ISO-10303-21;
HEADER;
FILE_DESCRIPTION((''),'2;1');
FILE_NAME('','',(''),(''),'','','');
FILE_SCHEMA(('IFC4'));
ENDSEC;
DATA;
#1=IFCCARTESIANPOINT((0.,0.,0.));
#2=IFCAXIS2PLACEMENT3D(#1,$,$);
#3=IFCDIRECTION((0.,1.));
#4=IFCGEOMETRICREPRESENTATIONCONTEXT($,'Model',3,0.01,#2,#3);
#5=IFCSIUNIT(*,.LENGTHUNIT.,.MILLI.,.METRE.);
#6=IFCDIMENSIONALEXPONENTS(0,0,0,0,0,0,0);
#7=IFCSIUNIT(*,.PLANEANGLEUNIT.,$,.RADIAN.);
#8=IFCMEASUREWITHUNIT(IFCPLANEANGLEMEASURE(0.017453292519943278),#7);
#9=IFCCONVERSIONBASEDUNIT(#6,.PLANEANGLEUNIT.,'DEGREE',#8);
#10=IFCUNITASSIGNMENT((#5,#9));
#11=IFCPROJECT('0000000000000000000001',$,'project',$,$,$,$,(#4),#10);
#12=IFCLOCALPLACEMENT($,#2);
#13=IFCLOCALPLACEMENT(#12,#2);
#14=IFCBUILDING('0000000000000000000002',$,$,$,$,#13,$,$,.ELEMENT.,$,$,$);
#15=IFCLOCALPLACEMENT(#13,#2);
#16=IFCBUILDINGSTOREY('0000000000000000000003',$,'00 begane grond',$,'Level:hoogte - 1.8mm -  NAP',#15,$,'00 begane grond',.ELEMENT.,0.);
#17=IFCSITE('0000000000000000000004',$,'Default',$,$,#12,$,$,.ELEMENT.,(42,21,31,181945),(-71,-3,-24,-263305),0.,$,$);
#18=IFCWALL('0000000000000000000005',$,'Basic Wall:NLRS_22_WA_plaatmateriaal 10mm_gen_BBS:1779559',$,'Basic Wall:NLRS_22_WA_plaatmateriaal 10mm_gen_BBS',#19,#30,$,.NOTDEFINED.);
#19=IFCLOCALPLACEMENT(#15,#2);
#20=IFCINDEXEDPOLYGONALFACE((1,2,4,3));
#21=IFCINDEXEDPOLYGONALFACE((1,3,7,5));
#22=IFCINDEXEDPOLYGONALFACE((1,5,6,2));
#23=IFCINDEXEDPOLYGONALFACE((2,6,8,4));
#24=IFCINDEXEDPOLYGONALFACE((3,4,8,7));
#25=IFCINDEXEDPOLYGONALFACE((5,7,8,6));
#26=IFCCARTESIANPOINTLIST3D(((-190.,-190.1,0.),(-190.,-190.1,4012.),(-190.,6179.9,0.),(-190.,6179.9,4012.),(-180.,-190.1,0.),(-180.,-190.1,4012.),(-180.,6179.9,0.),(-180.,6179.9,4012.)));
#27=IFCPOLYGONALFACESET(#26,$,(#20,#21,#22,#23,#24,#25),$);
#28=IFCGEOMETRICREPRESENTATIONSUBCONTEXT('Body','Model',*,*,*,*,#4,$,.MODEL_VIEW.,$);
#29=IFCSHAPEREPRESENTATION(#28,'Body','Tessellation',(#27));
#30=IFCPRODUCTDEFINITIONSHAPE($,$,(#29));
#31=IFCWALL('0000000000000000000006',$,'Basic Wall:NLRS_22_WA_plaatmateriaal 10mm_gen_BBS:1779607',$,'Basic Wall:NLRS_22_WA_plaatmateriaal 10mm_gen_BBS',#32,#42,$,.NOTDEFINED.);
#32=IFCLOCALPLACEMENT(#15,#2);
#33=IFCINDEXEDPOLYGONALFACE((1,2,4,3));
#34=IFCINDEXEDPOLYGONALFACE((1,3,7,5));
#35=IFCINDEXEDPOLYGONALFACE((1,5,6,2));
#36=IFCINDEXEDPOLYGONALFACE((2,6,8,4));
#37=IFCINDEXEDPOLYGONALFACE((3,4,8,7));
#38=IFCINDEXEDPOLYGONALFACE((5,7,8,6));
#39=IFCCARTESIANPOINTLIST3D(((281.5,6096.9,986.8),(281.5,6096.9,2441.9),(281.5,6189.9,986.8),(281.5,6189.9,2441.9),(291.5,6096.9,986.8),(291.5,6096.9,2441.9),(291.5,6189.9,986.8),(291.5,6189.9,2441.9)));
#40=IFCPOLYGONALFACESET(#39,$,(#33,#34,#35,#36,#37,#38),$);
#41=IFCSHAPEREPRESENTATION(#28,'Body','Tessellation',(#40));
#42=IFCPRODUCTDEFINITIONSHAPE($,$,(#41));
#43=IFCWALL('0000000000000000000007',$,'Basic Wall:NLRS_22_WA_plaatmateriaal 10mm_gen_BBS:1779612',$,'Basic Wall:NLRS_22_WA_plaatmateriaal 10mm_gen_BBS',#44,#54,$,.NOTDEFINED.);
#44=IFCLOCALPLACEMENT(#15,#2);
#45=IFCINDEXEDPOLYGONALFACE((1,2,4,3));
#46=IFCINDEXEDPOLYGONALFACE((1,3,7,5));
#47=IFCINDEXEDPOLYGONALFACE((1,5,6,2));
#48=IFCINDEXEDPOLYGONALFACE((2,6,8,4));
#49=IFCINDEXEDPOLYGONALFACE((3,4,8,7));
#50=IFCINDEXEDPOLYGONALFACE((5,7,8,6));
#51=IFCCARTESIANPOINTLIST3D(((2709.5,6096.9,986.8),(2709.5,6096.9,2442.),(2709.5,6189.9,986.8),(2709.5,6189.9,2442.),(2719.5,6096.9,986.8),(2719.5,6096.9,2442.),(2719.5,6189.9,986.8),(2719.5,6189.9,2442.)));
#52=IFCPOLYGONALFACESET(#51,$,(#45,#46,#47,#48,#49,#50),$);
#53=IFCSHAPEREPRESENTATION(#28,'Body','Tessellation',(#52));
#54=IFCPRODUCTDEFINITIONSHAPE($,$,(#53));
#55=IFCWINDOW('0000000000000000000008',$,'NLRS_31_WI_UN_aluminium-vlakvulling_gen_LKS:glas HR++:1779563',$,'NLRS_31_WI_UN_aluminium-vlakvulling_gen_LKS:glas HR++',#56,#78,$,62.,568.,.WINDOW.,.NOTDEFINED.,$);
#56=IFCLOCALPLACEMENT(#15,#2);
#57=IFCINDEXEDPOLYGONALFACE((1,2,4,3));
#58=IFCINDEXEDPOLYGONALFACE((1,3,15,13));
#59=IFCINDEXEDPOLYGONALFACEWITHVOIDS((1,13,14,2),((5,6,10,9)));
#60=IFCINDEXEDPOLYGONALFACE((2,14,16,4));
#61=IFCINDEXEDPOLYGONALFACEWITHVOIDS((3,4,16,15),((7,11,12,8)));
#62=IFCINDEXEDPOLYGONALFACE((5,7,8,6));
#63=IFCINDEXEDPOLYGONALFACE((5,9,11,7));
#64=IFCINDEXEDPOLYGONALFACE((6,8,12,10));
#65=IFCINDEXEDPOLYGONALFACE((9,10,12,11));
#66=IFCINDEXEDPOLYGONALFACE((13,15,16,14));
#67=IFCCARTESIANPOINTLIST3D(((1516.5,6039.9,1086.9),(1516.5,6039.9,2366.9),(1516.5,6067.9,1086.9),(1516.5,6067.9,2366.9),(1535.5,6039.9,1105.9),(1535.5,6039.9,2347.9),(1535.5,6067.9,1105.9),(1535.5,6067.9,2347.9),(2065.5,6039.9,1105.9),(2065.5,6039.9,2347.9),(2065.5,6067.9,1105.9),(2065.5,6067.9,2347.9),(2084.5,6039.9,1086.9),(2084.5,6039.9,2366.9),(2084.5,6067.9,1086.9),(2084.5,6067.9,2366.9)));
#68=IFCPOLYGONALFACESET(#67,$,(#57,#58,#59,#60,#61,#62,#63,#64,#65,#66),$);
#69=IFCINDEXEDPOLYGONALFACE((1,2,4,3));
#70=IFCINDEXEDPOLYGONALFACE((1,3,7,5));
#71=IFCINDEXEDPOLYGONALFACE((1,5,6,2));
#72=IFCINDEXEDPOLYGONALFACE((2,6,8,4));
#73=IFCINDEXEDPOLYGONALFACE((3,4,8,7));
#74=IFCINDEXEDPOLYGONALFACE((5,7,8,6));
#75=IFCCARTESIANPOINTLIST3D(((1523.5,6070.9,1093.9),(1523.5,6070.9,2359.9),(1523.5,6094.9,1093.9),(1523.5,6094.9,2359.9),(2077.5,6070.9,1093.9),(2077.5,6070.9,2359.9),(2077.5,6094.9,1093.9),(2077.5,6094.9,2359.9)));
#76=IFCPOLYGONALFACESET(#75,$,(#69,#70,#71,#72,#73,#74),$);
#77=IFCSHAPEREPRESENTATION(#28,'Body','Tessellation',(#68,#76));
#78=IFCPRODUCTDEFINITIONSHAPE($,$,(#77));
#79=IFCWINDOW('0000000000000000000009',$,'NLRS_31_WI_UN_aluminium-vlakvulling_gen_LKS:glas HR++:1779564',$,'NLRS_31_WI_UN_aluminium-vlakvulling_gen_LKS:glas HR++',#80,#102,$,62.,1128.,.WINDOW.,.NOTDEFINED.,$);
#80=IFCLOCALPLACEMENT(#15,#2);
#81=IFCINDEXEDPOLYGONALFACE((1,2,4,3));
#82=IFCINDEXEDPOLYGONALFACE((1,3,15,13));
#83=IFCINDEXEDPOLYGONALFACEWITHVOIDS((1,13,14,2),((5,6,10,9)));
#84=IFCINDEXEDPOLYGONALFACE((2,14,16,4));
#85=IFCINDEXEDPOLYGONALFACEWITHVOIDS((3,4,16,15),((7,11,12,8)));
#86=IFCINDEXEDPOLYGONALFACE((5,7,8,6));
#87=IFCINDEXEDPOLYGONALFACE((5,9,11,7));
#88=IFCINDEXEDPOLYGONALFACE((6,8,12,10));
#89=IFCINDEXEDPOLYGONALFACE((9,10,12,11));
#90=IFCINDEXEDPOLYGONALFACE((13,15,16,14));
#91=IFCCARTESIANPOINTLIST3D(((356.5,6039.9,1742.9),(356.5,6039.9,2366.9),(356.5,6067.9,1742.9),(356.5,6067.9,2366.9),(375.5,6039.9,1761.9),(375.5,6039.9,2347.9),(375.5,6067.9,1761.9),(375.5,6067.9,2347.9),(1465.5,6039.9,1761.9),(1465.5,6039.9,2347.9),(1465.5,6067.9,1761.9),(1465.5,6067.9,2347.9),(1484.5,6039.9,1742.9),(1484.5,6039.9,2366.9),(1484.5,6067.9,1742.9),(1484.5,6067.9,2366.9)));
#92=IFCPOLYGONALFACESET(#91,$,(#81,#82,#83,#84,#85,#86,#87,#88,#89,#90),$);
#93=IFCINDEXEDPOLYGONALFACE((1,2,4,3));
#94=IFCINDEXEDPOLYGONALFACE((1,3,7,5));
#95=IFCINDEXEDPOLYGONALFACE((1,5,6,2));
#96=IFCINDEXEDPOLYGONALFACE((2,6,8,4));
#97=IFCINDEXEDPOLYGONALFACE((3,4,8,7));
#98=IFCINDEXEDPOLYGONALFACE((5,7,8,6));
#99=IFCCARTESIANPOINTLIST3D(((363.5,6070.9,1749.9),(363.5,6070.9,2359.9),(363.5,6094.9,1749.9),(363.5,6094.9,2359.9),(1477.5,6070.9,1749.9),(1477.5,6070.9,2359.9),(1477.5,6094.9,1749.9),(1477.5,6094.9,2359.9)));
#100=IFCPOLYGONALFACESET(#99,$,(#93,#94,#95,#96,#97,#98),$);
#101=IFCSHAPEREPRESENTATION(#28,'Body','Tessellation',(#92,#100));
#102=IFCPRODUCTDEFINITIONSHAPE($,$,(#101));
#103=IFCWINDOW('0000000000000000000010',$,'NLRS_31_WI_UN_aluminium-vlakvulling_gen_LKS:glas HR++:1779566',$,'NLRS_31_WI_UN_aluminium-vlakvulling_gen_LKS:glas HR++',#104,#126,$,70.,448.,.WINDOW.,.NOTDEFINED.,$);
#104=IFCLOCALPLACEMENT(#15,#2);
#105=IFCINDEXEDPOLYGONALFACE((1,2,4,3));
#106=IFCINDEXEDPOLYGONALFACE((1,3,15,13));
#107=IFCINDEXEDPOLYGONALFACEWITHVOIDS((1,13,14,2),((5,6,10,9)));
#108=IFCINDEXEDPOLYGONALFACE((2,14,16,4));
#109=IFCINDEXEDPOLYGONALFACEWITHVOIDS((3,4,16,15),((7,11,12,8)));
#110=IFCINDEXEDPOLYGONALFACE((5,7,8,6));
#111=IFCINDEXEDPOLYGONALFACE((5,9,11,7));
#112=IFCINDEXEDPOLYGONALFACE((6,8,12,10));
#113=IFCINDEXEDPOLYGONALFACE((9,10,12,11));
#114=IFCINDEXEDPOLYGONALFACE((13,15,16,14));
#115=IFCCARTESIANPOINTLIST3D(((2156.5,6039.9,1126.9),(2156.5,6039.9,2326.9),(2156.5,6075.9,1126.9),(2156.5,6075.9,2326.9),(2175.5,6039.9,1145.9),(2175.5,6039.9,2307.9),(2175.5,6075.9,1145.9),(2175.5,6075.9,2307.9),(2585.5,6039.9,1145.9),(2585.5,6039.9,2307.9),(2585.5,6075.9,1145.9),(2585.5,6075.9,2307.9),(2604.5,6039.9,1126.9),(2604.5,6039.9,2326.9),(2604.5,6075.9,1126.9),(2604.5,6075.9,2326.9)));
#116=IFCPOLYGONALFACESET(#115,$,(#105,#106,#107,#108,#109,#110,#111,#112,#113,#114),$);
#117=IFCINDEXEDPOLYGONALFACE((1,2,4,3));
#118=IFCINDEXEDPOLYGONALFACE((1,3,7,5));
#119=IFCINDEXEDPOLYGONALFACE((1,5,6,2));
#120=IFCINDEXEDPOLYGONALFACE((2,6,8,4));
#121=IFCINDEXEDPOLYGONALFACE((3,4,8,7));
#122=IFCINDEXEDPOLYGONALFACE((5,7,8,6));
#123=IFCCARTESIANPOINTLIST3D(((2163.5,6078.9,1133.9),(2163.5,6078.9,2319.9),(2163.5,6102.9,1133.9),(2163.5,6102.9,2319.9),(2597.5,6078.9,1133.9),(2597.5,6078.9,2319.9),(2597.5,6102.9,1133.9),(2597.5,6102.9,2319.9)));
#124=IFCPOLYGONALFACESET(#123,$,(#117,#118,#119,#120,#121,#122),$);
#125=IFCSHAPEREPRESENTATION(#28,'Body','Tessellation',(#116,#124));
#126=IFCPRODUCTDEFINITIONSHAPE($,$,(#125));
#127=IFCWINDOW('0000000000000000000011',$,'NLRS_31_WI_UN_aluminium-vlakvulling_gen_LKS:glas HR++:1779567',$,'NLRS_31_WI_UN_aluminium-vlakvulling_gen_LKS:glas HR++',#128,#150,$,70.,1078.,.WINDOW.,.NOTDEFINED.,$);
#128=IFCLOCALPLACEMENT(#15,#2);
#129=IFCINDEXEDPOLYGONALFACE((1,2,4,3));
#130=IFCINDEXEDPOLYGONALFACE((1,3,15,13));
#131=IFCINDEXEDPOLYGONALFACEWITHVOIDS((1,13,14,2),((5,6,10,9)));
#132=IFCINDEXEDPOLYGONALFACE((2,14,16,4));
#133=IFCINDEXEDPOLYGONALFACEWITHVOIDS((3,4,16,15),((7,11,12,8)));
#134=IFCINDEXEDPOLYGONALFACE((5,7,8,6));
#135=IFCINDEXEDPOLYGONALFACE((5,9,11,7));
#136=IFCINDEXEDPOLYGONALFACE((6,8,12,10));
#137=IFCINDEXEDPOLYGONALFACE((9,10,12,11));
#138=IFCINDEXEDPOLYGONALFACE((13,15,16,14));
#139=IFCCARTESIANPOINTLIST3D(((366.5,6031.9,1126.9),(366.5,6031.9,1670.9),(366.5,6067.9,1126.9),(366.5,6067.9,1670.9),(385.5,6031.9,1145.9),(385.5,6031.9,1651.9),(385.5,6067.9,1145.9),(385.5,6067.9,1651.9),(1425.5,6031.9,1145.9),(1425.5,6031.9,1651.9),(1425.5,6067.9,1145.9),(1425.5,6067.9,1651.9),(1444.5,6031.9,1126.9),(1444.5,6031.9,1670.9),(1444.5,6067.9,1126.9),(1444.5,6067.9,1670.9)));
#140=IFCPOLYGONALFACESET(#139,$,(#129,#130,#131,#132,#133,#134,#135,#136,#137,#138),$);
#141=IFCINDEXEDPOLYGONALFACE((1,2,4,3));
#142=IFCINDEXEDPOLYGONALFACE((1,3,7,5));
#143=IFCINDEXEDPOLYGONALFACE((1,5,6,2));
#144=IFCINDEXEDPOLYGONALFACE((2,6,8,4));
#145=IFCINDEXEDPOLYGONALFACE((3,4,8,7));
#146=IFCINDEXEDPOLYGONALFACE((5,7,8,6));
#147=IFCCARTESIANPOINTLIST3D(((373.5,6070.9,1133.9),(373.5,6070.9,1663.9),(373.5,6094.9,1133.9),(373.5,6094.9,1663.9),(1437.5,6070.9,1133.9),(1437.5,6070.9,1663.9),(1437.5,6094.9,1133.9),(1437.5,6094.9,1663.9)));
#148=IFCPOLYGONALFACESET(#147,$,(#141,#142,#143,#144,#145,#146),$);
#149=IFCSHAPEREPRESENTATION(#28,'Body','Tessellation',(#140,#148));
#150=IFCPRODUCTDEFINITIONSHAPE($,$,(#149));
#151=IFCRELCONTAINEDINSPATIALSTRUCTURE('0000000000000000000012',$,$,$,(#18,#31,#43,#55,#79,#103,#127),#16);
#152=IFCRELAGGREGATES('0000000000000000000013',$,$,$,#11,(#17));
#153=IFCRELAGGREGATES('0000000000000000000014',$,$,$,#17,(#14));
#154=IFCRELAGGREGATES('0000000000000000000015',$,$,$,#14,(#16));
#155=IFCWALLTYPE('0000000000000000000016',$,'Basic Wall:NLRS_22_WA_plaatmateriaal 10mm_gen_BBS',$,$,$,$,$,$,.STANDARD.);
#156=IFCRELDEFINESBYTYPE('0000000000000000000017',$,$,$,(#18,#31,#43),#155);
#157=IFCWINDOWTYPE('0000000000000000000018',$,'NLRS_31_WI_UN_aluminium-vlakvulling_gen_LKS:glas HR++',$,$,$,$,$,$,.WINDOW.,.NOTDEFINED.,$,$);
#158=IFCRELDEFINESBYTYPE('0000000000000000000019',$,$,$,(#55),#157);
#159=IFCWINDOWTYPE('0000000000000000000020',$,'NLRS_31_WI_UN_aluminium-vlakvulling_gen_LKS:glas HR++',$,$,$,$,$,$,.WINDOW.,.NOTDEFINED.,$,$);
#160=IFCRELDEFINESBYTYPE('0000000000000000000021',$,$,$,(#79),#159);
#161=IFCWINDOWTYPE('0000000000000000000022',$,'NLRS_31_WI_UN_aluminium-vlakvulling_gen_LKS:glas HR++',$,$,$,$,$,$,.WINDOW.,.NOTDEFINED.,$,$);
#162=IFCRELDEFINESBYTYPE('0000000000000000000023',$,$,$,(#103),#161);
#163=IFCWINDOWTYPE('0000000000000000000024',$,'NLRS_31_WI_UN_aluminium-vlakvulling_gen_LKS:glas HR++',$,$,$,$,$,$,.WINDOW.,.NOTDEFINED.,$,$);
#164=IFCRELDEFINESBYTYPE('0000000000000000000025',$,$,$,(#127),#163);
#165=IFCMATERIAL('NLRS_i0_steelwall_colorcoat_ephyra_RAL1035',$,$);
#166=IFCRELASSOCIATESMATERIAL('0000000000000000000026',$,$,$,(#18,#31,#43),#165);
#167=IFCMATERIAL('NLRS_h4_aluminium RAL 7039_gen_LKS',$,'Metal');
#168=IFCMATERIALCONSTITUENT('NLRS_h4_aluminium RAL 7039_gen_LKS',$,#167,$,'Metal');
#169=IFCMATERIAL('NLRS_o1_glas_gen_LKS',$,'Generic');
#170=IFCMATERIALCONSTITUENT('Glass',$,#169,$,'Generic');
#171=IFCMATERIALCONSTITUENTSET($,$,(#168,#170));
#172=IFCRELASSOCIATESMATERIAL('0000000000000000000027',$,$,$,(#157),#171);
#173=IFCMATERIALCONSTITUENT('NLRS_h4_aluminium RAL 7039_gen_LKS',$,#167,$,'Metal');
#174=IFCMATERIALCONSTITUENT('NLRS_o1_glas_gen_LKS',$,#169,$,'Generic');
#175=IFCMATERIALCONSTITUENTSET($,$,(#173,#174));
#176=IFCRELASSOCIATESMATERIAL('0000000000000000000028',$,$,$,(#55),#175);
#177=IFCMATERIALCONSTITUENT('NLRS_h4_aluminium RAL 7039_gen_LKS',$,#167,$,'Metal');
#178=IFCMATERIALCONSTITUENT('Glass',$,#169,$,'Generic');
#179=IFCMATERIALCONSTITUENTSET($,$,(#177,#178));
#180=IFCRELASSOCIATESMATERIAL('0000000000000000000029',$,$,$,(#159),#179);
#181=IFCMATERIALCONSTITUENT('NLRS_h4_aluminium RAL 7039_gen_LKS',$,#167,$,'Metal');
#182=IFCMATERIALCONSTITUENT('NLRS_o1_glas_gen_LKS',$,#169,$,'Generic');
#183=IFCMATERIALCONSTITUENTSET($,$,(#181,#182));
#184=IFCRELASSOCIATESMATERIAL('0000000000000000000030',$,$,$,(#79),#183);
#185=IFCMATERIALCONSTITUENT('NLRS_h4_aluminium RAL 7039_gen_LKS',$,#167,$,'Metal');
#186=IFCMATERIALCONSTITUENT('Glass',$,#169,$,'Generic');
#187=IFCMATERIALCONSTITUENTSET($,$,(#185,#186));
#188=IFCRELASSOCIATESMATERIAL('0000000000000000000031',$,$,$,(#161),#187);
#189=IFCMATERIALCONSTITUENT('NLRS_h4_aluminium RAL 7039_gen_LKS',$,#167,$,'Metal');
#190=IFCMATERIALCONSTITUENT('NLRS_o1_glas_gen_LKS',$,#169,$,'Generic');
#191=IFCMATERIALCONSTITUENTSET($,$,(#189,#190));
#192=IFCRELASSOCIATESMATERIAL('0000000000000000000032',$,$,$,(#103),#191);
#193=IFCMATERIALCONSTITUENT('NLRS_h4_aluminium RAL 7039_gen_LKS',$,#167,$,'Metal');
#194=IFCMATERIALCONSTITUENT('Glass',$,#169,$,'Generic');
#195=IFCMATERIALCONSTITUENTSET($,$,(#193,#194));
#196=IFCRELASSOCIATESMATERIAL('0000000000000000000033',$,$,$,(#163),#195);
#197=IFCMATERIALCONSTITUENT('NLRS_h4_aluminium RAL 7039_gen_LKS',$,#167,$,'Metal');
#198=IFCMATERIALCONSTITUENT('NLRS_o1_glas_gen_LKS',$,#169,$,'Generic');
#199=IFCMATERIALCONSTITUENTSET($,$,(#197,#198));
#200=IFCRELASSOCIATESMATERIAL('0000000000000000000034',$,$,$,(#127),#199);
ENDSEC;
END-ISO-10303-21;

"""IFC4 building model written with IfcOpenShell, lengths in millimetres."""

from ifc_helpers import new_model, entity, si_unit, converted_unit, direction, frame, origin, place, context, subcontext, project, spatial, indexed_curve, outline, extrude, source, transform, mapped, material, constituent, constituent_set, type_object, type_shapes, element, save


model = new_model("IFC4")

# Units and contexts
model_context = context("Model", 3, precision=0.01, world=origin(), true_north=direction((0.0, 1.0)))
body_context = subcontext(model_context, "Body", "Model", "MODEL_VIEW")
ifc_project = project(units=[si_unit("LENGTHUNIT", "METRE", prefix="MILLI"), converted_unit("PLANEANGLEUNIT", "DEGREE", entity("IfcPlaneAngleMeasure", 0.017453292519943278), si_unit("PLANEANGLEUNIT", "RADIAN"), dimensions=[0, 0, 0, 0, 0, 0, 0])], contexts=[model_context])

# Site, building, storey
site_placement = place(None, origin())
site = spatial("IfcSite", under=ifc_project, at=site_placement, Name="Default", CompositionType="ELEMENT", RefLatitude=(42, 21, 31, 181945), RefLongitude=(-71, -3, -24, -263305), RefElevation=0.0)
building_placement = place(site_placement, origin())
building = spatial("IfcBuilding", under=site, at=building_placement, CompositionType="ELEMENT")
storey_placement = place(building_placement, origin())
storey = spatial("IfcBuildingStorey", under=building, at=storey_placement, Name="00 begane grond", ObjectType="Level:hoogte - 1.8mm -  NAP", LongName="00 begane grond", CompositionType="ELEMENT", Elevation=0.0)

# Walls
ifc_material_1 = material(Name="NLRS_i0_steelwall_colorcoat_ephyra_RAL1035")
wall_type_1 = type_object("IfcWallType", Name="Basic Wall:NLRS_22_WA_plaatmateriaal 10mm_gen_BBS", PredefinedType="STANDARD")
wall_1_placement = place(storey_placement, frame((-185.0, 6179.9, 0.0), z_axis=(0.0, 0.0, 1.0), x_axis=(0.0, -1.0, 0.0)))
element("IfcWall", 1, at=wall_1_placement, inside=storey, type_object=wall_type_1, material=ifc_material_1, Name="Basic Wall:NLRS_22_WA_plaatmateriaal 10mm_gen_BBS:1779559", ObjectType="Basic Wall:NLRS_22_WA_plaatmateriaal 10mm_gen_BBS", PredefinedType="NOTDEFINED", context=body_context, shape_type="SweptSolid", body=[
    extrude(outline(indexed_curve([(6370.0, 5.0), (0.0, 5.0), (0.0, -5.0), (6370.0, -5.0), (6370.0, 5.0)], self_intersect=False)), origin(), (0.0, 0.0, 1.0), 4012.0),
])
wall_2_placement = place(storey_placement, frame((286.5, 6096.9, 986.8), z_axis=(0.0, 0.0, 1.0), x_axis=(0.0, 1.0, 0.0)))
element("IfcWall", 2, at=wall_2_placement, inside=storey, type_object=wall_type_1, material=ifc_material_1, Name="Basic Wall:NLRS_22_WA_plaatmateriaal 10mm_gen_BBS:1779607", ObjectType="Basic Wall:NLRS_22_WA_plaatmateriaal 10mm_gen_BBS", PredefinedType="NOTDEFINED", context=body_context, shape_type="SweptSolid", body=[
    extrude(outline(indexed_curve([(93.0, 5.0), (0.0, 5.0), (0.0, -5.0), (93.0, -5.0), (93.0, 5.0)], self_intersect=False)), origin(), (0.0, 0.0, 1.0), 1455.1),
])
wall_3_placement = place(storey_placement, frame((2714.5, 6096.9, 986.8), z_axis=(0.0, 0.0, 1.0), x_axis=(0.0, 1.0, 0.0)))
element("IfcWall", 3, at=wall_3_placement, inside=storey, type_object=wall_type_1, material=ifc_material_1, Name="Basic Wall:NLRS_22_WA_plaatmateriaal 10mm_gen_BBS:1779612", ObjectType="Basic Wall:NLRS_22_WA_plaatmateriaal 10mm_gen_BBS", PredefinedType="NOTDEFINED", context=body_context, shape_type="SweptSolid", body=[
    extrude(outline(indexed_curve([(93.0, 5.0), (0.0, 5.0), (0.0, -5.0), (93.0, -5.0), (93.0, 5.0)], self_intersect=False)), origin(), (0.0, 0.0, 1.0), 1455.2),
])

# Windows
ifc_material_2 = material(Name="NLRS_h4_aluminium RAL 7039_gen_LKS", Category="Metal")
ifc_constituent_1 = constituent(ifc_material_2, Name="NLRS_h4_aluminium RAL 7039_gen_LKS", Category="Metal")
ifc_material_3 = material(Name="NLRS_o1_glas_gen_LKS", Category="Generic")
ifc_constituent_2 = constituent(ifc_material_3, Name="NLRS_o1_glas_gen_LKS", Category="Generic")
ifc_constituent_set_1 = constituent_set(constituents=[ifc_constituent_1, ifc_constituent_2])
ifc_constituent_3 = constituent(ifc_material_2, Name="NLRS_h4_aluminium RAL 7039_gen_LKS", Category="Metal")
ifc_constituent_4 = constituent(ifc_material_3, Name="Glass", Category="Generic")
ifc_constituent_set_2 = constituent_set(constituents=[ifc_constituent_3, ifc_constituent_4])
window_type_1 = type_object("IfcWindowType", Name="NLRS_31_WI_UN_aluminium-vlakvulling_gen_LKS:glas HR++", PartitioningType="NOTDEFINED", PredefinedType="WINDOW", material=ifc_constituent_set_2)
shared_shape_1 = source(origin(), body_context, "Body", "SweptSolid", [
    extrude(outline(indexed_curve([(-640.0, -284.0), (640.0, -284.0), (640.0, 284.0), (-640.0, 284.0), (-640.0, -284.0)], self_intersect=False), holes=[indexed_curve([(621.0, -265.0), (-621.0, -265.0), (-621.0, 265.0), (621.0, 265.0), (621.0, -265.0)], self_intersect=False)]), frame((0.0, 34.0, 640.0), z_axis=(0.0, 1.0, 0.0), x_axis=(0.0, 0.0, -1.0)), (0.0, 0.0, 1.0), 28.0),
    extrude(outline(indexed_curve([(-12.0, -277.0), (12.0, -277.0), (12.0, 277.0), (-12.0, 277.0), (-12.0, -277.0)], self_intersect=False)), frame((0.0, 19.0, 7.0), z_axis=(0.0, 0.0, 1.0), x_axis=(0.0, -1.0, 0.0)), (0.0, 0.0, 1.0), 1266.0),
])
type_shapes(window_type_1, [shared_shape_1])
window_1_placement = place(storey_placement, frame((1800.5, 6101.9, 1086.9), z_axis=(0.0, 0.0, 1.0), x_axis=(-1.0, 0.0, 0.0)))
element("IfcWindow", 4, at=window_1_placement, inside=storey, type_object=window_type_1, material=ifc_constituent_set_1, Name="NLRS_31_WI_UN_aluminium-vlakvulling_gen_LKS:glas HR++:1779563", ObjectType="NLRS_31_WI_UN_aluminium-vlakvulling_gen_LKS:glas HR++", OverallHeight=62.0, OverallWidth=568.0, PartitioningType="NOTDEFINED", PredefinedType="WINDOW", context=body_context, shape_type="MappedRepresentation", body=[
    mapped(shared_shape_1, transform((0.0, 0.0, 0.0), scale=1.0)),
])
ifc_constituent_5 = constituent(ifc_material_2, Name="NLRS_h4_aluminium RAL 7039_gen_LKS", Category="Metal")
ifc_constituent_6 = constituent(ifc_material_3, Name="NLRS_o1_glas_gen_LKS", Category="Generic")
ifc_constituent_set_3 = constituent_set(constituents=[ifc_constituent_5, ifc_constituent_6])
ifc_constituent_7 = constituent(ifc_material_2, Name="NLRS_h4_aluminium RAL 7039_gen_LKS", Category="Metal")
ifc_constituent_8 = constituent(ifc_material_3, Name="Glass", Category="Generic")
ifc_constituent_set_4 = constituent_set(constituents=[ifc_constituent_7, ifc_constituent_8])
window_type_2 = type_object("IfcWindowType", Name="NLRS_31_WI_UN_aluminium-vlakvulling_gen_LKS:glas HR++", PartitioningType="NOTDEFINED", PredefinedType="WINDOW", material=ifc_constituent_set_4)
shared_shape_2 = source(origin(), body_context, "Body", "SweptSolid", [
    extrude(outline(indexed_curve([(-312.0, -564.0), (312.0, -564.0), (312.0, 564.0), (-312.0, 564.0), (-312.0, -564.0)], self_intersect=False), holes=[indexed_curve([(293.0, -545.0), (-293.0, -545.0), (-293.0, 545.0), (293.0, 545.0), (293.0, -545.0)], self_intersect=False)]), frame((0.0, 34.0, 312.0), z_axis=(0.0, 1.0, 0.0), x_axis=(0.0, 0.0, -1.0)), (0.0, 0.0, 1.0), 28.0),
    extrude(outline(indexed_curve([(-12.0, -557.0), (12.0, -557.0), (12.0, 557.0), (-12.0, 557.0), (-12.0, -557.0)], self_intersect=False)), frame((0.0, 19.0, 7.0), z_axis=(0.0, 0.0, 1.0), x_axis=(0.0, -1.0, 0.0)), (0.0, 0.0, 1.0), 610.0),
])
type_shapes(window_type_2, [shared_shape_2])
window_2_placement = place(storey_placement, frame((920.5, 6101.9, 1742.9), z_axis=(0.0, 0.0, 1.0), x_axis=(-1.0, 0.0, 0.0)))
element("IfcWindow", 5, at=window_2_placement, inside=storey, type_object=window_type_2, material=ifc_constituent_set_3, Name="NLRS_31_WI_UN_aluminium-vlakvulling_gen_LKS:glas HR++:1779564", ObjectType="NLRS_31_WI_UN_aluminium-vlakvulling_gen_LKS:glas HR++", OverallHeight=62.0, OverallWidth=1128.0, PartitioningType="NOTDEFINED", PredefinedType="WINDOW", context=body_context, shape_type="MappedRepresentation", body=[
    mapped(shared_shape_2, transform((0.0, 0.0, 0.0), scale=1.0)),
])
ifc_constituent_9 = constituent(ifc_material_2, Name="NLRS_h4_aluminium RAL 7039_gen_LKS", Category="Metal")
ifc_constituent_10 = constituent(ifc_material_3, Name="NLRS_o1_glas_gen_LKS", Category="Generic")
ifc_constituent_set_5 = constituent_set(constituents=[ifc_constituent_9, ifc_constituent_10])
ifc_constituent_11 = constituent(ifc_material_2, Name="NLRS_h4_aluminium RAL 7039_gen_LKS", Category="Metal")
ifc_constituent_12 = constituent(ifc_material_3, Name="Glass", Category="Generic")
ifc_constituent_set_6 = constituent_set(constituents=[ifc_constituent_11, ifc_constituent_12])
window_type_3 = type_object("IfcWindowType", Name="NLRS_31_WI_UN_aluminium-vlakvulling_gen_LKS:glas HR++", PartitioningType="NOTDEFINED", PredefinedType="WINDOW", material=ifc_constituent_set_6)
shared_shape_3 = source(origin(), body_context, "Body", "SweptSolid", [
    extrude(outline(indexed_curve([(-600.0, -224.0), (600.0, -224.0), (600.0, 224.0), (-600.0, 224.0), (-600.0, -224.0)], self_intersect=False), holes=[indexed_curve([(581.0, -205.0), (-581.0, -205.0), (-581.0, 205.0), (581.0, 205.0), (581.0, -205.0)], self_intersect=False)]), frame((0.0, 34.0, 600.0), z_axis=(0.0, 1.0, 0.0), x_axis=(0.0, 0.0, -1.0)), (0.0, 0.0, 1.0), 36.0),
    extrude(outline(indexed_curve([(-12.0, -217.0), (12.0, -217.0), (12.0, 217.0), (-12.0, 217.0), (-12.0, -217.0)], self_intersect=False)), frame((0.0, 19.0, 7.0), z_axis=(0.0, 0.0, 1.0), x_axis=(0.0, -1.0, 0.0)), (0.0, 0.0, 1.0), 1186.0),
])
type_shapes(window_type_3, [shared_shape_3])
window_3_placement = place(storey_placement, frame((2380.5, 6109.9, 1126.9), z_axis=(0.0, 0.0, 1.0), x_axis=(-1.0, 0.0, 0.0)))
element("IfcWindow", 6, at=window_3_placement, inside=storey, type_object=window_type_3, material=ifc_constituent_set_5, Name="NLRS_31_WI_UN_aluminium-vlakvulling_gen_LKS:glas HR++:1779566", ObjectType="NLRS_31_WI_UN_aluminium-vlakvulling_gen_LKS:glas HR++", OverallHeight=70.0, OverallWidth=448.0, PartitioningType="NOTDEFINED", PredefinedType="WINDOW", context=body_context, shape_type="MappedRepresentation", body=[
    mapped(shared_shape_3, transform((0.0, 0.0, 0.0), scale=1.0)),
])
ifc_constituent_13 = constituent(ifc_material_2, Name="NLRS_h4_aluminium RAL 7039_gen_LKS", Category="Metal")
ifc_constituent_14 = constituent(ifc_material_3, Name="NLRS_o1_glas_gen_LKS", Category="Generic")
ifc_constituent_set_7 = constituent_set(constituents=[ifc_constituent_13, ifc_constituent_14])
ifc_constituent_15 = constituent(ifc_material_2, Name="NLRS_h4_aluminium RAL 7039_gen_LKS", Category="Metal")
ifc_constituent_16 = constituent(ifc_material_3, Name="Glass", Category="Generic")
ifc_constituent_set_8 = constituent_set(constituents=[ifc_constituent_15, ifc_constituent_16])
window_type_4 = type_object("IfcWindowType", Name="NLRS_31_WI_UN_aluminium-vlakvulling_gen_LKS:glas HR++", PartitioningType="NOTDEFINED", PredefinedType="WINDOW", material=ifc_constituent_set_8)
shared_shape_4 = source(origin(), body_context, "Body", "SweptSolid", [
    extrude(outline(indexed_curve([(-272.0, -539.0), (272.0, -539.0), (272.0, 539.0), (-272.0, 539.0), (-272.0, -539.0)], self_intersect=False), holes=[indexed_curve([(253.0, -520.0), (-253.0, -520.0), (-253.0, 520.0), (253.0, 520.0), (253.0, -520.0)], self_intersect=False)]), frame((0.0, 34.0, 272.0), z_axis=(0.0, 1.0, 0.0), x_axis=(0.0, 0.0, -1.0)), (0.0, 0.0, 1.0), 36.0),
    extrude(outline(indexed_curve([(-12.0, -532.0), (12.0, -532.0), (12.0, 532.0), (-12.0, 532.0), (-12.0, -532.0)], self_intersect=False)), frame((0.0, 19.0, 7.0), z_axis=(0.0, 0.0, 1.0), x_axis=(0.0, -1.0, 0.0)), (0.0, 0.0, 1.0), 530.0),
])
type_shapes(window_type_4, [shared_shape_4])
window_4_placement = place(storey_placement, frame((905.5, 6101.9, 1126.9), z_axis=(0.0, 0.0, 1.0), x_axis=(-1.0, 0.0, 0.0)))
element("IfcWindow", 7, at=window_4_placement, inside=storey, type_object=window_type_4, material=ifc_constituent_set_7, Name="NLRS_31_WI_UN_aluminium-vlakvulling_gen_LKS:glas HR++:1779567", ObjectType="NLRS_31_WI_UN_aluminium-vlakvulling_gen_LKS:glas HR++", OverallHeight=70.0, OverallWidth=1078.0, PartitioningType="NOTDEFINED", PredefinedType="WINDOW", context=body_context, shape_type="MappedRepresentation", body=[
    mapped(shared_shape_4, transform((0.0, 0.0, 0.0), scale=1.0)),
])

save(model, "model.ifc")
